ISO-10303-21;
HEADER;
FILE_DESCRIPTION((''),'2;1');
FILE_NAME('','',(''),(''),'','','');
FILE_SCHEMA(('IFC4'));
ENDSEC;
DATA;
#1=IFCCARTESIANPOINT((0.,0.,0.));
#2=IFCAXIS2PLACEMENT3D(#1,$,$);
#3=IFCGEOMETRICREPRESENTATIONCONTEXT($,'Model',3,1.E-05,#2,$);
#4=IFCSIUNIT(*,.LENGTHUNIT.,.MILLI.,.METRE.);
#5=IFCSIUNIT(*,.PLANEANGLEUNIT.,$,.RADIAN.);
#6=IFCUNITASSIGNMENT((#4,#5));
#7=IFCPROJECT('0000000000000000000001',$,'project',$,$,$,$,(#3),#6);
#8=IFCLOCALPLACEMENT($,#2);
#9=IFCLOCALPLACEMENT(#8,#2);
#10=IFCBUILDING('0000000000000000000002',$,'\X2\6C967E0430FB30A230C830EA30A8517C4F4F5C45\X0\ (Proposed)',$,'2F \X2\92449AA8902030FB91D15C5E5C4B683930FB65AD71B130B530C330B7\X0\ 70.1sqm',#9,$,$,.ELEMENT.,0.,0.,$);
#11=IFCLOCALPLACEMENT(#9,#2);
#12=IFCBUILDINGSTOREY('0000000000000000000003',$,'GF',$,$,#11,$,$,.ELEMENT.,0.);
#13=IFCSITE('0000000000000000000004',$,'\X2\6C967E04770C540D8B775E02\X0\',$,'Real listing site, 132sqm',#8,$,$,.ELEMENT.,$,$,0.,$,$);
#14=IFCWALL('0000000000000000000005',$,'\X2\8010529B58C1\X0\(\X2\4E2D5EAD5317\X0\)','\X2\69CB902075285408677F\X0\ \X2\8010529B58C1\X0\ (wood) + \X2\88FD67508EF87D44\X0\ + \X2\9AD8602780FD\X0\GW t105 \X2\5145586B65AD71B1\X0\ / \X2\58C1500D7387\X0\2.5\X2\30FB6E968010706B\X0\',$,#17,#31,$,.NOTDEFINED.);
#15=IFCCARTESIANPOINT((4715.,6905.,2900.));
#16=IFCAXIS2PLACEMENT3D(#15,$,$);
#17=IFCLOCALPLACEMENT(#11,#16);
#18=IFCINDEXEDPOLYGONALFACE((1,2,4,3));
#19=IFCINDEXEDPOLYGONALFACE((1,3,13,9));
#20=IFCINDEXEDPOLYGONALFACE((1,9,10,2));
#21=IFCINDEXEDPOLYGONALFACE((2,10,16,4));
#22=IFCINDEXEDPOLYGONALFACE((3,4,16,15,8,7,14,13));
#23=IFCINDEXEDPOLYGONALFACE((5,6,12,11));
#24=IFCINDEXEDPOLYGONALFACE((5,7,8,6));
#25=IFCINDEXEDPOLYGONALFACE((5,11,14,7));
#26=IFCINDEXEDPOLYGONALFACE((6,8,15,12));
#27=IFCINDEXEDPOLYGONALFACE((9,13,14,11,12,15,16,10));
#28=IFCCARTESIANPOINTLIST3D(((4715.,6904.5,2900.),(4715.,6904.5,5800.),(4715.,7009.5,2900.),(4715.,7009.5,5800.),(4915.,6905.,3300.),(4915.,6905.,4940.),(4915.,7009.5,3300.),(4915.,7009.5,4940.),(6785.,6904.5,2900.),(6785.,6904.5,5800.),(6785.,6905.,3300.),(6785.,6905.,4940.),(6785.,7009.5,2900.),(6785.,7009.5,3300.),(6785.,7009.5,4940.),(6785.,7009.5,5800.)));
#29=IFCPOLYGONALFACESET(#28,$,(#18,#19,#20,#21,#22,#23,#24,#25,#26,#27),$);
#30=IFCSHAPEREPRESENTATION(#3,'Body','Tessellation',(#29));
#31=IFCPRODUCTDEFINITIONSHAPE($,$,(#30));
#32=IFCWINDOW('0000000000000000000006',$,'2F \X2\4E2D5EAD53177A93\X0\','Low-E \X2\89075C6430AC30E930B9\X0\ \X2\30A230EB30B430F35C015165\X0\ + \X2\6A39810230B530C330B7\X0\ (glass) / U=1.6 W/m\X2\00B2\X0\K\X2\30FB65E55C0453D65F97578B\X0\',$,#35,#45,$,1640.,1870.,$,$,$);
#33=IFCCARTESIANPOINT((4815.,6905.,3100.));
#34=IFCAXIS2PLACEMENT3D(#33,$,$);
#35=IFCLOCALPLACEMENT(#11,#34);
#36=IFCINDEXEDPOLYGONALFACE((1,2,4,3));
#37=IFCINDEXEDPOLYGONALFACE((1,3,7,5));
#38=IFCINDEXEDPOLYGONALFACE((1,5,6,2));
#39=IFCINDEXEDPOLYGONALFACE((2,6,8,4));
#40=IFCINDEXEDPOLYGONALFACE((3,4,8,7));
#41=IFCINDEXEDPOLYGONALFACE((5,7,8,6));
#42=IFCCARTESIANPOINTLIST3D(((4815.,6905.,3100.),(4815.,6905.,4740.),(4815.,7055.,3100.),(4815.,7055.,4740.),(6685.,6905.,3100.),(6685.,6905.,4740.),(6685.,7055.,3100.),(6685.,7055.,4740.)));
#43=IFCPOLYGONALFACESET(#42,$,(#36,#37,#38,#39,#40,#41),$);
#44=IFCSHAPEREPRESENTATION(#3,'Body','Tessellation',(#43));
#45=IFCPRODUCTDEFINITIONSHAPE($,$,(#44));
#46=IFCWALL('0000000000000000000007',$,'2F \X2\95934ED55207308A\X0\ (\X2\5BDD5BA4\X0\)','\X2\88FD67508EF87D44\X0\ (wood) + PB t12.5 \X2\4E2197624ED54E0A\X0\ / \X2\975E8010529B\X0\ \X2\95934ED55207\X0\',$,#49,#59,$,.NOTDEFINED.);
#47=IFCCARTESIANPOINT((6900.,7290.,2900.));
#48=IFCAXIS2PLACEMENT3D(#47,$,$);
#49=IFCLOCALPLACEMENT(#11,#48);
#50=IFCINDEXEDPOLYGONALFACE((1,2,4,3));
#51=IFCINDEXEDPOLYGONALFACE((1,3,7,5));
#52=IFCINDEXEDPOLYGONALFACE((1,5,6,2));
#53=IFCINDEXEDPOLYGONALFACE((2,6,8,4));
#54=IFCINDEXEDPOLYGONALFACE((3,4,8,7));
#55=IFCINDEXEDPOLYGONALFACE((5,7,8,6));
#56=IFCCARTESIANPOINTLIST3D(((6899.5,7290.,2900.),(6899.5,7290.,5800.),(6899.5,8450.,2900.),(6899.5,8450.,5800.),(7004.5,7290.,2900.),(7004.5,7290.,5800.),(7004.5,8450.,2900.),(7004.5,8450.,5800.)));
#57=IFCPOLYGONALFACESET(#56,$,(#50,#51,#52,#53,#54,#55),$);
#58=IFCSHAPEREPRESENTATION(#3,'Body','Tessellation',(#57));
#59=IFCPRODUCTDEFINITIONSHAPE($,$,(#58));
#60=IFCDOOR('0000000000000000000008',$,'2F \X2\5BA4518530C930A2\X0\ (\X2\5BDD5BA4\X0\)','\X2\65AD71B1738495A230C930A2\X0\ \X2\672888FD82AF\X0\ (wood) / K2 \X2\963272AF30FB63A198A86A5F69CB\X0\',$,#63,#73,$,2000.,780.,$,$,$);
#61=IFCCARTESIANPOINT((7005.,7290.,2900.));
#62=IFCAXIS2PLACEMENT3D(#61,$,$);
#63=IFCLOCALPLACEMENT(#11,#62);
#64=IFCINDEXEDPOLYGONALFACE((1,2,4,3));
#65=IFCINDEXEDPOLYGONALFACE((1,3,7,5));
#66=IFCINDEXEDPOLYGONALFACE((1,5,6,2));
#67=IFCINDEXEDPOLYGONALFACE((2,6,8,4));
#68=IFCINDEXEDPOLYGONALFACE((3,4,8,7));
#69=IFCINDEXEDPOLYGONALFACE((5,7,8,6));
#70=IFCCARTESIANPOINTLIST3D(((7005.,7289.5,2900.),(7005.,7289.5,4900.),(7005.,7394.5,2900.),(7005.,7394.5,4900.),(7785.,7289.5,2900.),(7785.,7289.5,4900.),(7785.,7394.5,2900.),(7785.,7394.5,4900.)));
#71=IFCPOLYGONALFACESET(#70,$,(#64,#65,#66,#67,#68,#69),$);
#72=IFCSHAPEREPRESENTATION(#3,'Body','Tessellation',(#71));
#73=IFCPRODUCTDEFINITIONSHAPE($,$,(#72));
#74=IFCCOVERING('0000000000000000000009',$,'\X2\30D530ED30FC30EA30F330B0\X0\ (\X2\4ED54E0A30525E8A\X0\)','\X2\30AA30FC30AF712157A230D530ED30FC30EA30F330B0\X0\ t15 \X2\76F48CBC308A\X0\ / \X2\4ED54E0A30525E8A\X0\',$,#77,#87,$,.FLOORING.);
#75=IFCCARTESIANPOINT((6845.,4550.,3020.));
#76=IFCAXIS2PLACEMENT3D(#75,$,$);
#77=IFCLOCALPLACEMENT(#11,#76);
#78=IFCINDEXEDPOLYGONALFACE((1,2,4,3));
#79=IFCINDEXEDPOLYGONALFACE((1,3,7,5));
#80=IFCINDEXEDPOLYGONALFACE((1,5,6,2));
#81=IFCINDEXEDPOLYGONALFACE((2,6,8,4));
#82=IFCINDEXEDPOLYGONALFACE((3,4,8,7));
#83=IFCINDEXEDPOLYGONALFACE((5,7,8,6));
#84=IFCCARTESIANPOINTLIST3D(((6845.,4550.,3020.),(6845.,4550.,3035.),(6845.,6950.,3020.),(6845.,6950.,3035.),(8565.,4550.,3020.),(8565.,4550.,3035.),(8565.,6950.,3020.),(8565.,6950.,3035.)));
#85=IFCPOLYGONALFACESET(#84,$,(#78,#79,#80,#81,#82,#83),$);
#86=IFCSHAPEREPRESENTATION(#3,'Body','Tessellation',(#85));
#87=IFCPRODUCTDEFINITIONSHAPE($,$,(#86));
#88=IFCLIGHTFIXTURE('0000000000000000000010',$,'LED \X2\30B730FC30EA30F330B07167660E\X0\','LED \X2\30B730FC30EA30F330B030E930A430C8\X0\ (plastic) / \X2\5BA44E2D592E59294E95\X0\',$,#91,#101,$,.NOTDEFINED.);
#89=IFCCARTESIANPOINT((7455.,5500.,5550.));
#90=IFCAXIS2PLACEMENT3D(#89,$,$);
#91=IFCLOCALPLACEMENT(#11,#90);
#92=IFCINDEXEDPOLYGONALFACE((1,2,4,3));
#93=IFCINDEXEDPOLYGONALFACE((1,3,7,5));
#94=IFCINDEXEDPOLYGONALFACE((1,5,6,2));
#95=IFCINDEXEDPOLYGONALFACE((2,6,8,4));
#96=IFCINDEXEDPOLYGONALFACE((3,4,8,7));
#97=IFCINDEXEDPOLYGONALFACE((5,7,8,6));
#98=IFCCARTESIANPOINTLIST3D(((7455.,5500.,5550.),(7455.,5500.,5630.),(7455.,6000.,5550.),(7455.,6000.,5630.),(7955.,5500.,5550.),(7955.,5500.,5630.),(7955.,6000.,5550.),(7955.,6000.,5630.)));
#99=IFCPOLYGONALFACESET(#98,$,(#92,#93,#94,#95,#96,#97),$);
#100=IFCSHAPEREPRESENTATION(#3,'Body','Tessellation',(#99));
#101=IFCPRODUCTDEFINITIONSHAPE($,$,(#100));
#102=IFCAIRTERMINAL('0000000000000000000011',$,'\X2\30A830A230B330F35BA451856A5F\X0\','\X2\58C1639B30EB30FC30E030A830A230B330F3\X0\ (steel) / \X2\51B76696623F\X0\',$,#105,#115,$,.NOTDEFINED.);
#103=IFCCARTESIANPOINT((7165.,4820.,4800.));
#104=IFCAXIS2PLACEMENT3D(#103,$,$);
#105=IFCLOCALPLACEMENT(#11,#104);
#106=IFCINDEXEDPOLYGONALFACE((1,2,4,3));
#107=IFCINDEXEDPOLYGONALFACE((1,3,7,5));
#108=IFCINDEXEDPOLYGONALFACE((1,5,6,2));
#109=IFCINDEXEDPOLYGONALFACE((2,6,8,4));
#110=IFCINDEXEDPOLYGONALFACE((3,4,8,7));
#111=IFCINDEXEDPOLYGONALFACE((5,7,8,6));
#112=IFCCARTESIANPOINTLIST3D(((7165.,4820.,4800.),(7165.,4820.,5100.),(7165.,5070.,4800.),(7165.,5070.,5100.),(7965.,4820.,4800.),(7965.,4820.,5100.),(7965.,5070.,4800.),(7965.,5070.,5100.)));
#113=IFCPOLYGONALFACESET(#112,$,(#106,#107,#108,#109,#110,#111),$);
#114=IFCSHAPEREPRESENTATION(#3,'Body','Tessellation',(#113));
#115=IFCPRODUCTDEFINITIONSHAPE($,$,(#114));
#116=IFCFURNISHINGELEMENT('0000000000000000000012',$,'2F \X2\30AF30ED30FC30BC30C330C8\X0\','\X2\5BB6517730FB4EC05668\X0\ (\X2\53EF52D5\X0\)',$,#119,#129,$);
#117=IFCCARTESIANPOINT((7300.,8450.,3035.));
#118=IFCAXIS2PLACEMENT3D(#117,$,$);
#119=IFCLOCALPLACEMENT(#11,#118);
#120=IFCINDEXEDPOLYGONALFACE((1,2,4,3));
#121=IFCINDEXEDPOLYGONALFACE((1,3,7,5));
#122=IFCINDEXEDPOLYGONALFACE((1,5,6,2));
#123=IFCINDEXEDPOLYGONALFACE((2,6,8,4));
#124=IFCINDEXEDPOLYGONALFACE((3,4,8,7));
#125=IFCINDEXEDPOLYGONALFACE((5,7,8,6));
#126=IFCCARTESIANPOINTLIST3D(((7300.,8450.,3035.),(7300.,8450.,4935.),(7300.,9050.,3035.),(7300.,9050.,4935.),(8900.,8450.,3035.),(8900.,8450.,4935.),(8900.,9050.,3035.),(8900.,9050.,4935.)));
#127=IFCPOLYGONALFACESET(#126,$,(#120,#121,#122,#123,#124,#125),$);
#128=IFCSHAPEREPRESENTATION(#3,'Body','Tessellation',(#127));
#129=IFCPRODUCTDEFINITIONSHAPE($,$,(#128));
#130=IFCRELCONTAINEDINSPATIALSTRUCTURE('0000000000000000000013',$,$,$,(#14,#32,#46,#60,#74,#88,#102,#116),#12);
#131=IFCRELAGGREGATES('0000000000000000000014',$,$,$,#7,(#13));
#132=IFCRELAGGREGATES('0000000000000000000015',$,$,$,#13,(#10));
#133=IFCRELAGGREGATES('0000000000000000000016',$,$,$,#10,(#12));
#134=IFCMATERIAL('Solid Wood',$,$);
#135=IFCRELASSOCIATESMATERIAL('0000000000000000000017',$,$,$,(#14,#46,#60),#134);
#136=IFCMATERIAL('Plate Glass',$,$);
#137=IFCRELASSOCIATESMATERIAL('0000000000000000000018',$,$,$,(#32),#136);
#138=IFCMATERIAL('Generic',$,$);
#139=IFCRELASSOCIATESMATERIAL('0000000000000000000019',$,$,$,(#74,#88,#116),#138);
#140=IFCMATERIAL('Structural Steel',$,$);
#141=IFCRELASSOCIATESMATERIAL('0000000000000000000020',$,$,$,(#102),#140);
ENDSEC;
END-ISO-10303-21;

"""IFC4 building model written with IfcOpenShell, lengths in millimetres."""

from ifc_helpers import new_model, si_unit, frame, frame_2d, origin, place, context, project, spatial, rectangle, extrude, material, element, fill, save


model = new_model("IFC4")

# Units and contexts
model_context = context("Model", 3, precision=1e-05, world=origin())
ifc_project = project(units=[si_unit("LENGTHUNIT", "METRE", prefix="MILLI"), si_unit("PLANEANGLEUNIT", "RADIAN")], contexts=[model_context])

# Site, building, storey
site_placement = place(None, origin())
site = spatial("IfcSite", under=ifc_project, at=site_placement, Name="沖縄県名護市", ObjectType="Real listing site, 132sqm", CompositionType="ELEMENT", RefElevation=0.0)
building_placement = place(site_placement, origin())
building = spatial("IfcBuilding", under=site, at=building_placement, Name="沖縄・アトリエ兼住居 (Proposed)", ObjectType="2F 鉄骨造・金属屋根・断熱サッシ 70.1sqm", CompositionType="ELEMENT", ElevationOfRefHeight=0.0, ElevationOfTerrain=0.0)
storey_placement = place(building_placement, origin())
storey = spatial("IfcBuildingStorey", under=building, at=storey_placement, Name="GF", CompositionType="ELEMENT", Elevation=0.0)

# Shared definitions
ifc_material_1 = material(Name="Solid Wood")

# Wall, opening, window
wall_1_placement = place(storey_placement, frame((4715.0, 6905.0, 2900.0)))
wall_1 = element("IfcWall", 1, at=wall_1_placement, inside=storey, material=ifc_material_1, Name="耐力壁(中庭北)", Description="構造用合板 耐力壁 (wood) + 製材軸組 + 高性能GW t105 充填断熱 / 壁倍率2.5・準耐火", PredefinedType="NOTDEFINED", context=model_context, shape_type="SweptSolid", body=[
    extrude(rectangle(XDim=2070.0, YDim=105.0, at=frame_2d((1035.0, 52.0))), frame((4715.0, 6905.0, 2900.0)), (0.0, 0.0, 1.0), 2900.0),
])
opening_placement = place(storey_placement, frame((4815.0, 6905.0, 3100.0)))
opening = element("IfcOpeningElement", 2, at=opening_placement, cuts=wall_1, PredefinedType="NOTDEFINED", context=model_context, shape_type="SweptSolid", body=[
    extrude(rectangle(XDim=1870.0, YDim=150.0, at=frame_2d((935.0, 75.0))), frame((4815.0, 6905.0, 3100.0)), (0.0, 0.0, 1.0), 1640.0),
])
ifc_material_2 = material(Name="Plate Glass")
window_placement = place(storey_placement, frame((4815.0, 6905.0, 3100.0)))
window = element("IfcWindow", 3, at=window_placement, inside=storey, material=ifc_material_2, Name="2F 中庭北窓", Description="Low-E 複層ガラス アルゴン封入 + 樹脂サッシ (glass) / U=1.6 W/m²K・日射取得型", OverallHeight=1640.0, OverallWidth=1870.0, context=model_context, shape_type="SweptSolid", body=[
    extrude(rectangle(XDim=1870.0, YDim=150.0, at=frame_2d((935.0, 75.0))), frame((4815.0, 6905.0, 3100.0)), (0.0, 0.0, 1.0), 1640.0),
])
fill(opening, window)

# Wall
wall_2_placement = place(storey_placement, frame((6900.0, 7290.0, 2900.0)))
element("IfcWall", 4, at=wall_2_placement, inside=storey, material=ifc_material_1, Name="2F 間仕切り (寝室)", Description="製材軸組 (wood) + PB t12.5 両面仕上 / 非耐力 間仕切", PredefinedType="NOTDEFINED", context=model_context, shape_type="SweptSolid", body=[
    extrude(rectangle(XDim=105.0, YDim=1160.0, at=frame_2d((52.0, 580.0))), frame((6900.0, 7290.0, 2900.0)), (0.0, 0.0, 1.0), 2900.0),
])

# Door
door_placement = place(storey_placement, frame((7005.0, 7290.0, 2900.0)))
element("IfcDoor", 5, at=door_placement, inside=storey, material=ifc_material_1, Name="2F 室内ドア (寝室)", Description="断熱玄関ドア 木製芯 (wood) / K2 防犯・採風機構", OverallHeight=2000.0, OverallWidth=780.0, context=model_context, shape_type="SweptSolid", body=[
    extrude(rectangle(XDim=780.0, YDim=105.0, at=frame_2d((390.0, 52.0))), frame((7005.0, 7290.0, 2900.0)), (0.0, 0.0, 1.0), 2000.0),
])

# Covering
ifc_material_3 = material(Name="Generic")
covering_placement = place(storey_placement, frame((6845.0, 4550.0, 3020.0)))
element("IfcCovering", 6, at=covering_placement, inside=storey, material=ifc_material_3, Name="フローリング (仕上げ床)", Description="オーク無垢フローリング t15 直貼り / 仕上げ床", PredefinedType="FLOORING", context=model_context, shape_type="SweptSolid", body=[
    extrude(rectangle(XDim=1720.0, YDim=2400.0, at=frame_2d((860.0, 1200.0))), frame((6845.0, 4550.0, 3020.0)), (0.0, 0.0, 1.0), 15.0),
])

# Light fixture
light_fixture_placement = place(storey_placement, frame((7455.0, 5500.0, 5550.0)))
element("IfcLightFixture", 7, at=light_fixture_placement, inside=storey, material=ifc_material_3, Name="LED シーリング照明", Description="LED シーリングライト (plastic) / 室中央天井", PredefinedType="NOTDEFINED", context=model_context, shape_type="SweptSolid", body=[
    extrude(rectangle(XDim=500.0, YDim=500.0, at=frame_2d((250.0, 250.0))), frame((7455.0, 5500.0, 5550.0)), (0.0, 0.0, 1.0), 80.0),
])

# Air terminal
ifc_material_4 = material(Name="Structural Steel")
air_terminal_placement = place(storey_placement, frame((7165.0, 4820.0, 4800.0)))
element("IfcAirTerminal", 8, at=air_terminal_placement, inside=storey, material=ifc_material_4, Name="エアコン室内機", Description="壁掛ルームエアコン (steel) / 冷暖房", PredefinedType="NOTDEFINED", context=model_context, shape_type="SweptSolid", body=[
    extrude(rectangle(XDim=800.0, YDim=250.0, at=frame_2d((400.0, 125.0))), frame((7165.0, 4820.0, 4800.0)), (0.0, 0.0, 1.0), 300.0),
])

# Furnishing element
furnishing_placement = place(storey_placement, frame((7300.0, 8450.0, 3035.0)))
element("IfcFurnishingElement", 9, at=furnishing_placement, inside=storey, material=ifc_material_3, Name="2F クローゼット", Description="家具・什器 (可動)", context=model_context, shape_type="SweptSolid", body=[
    extrude(rectangle(XDim=1600.0, YDim=600.0, at=frame_2d((800.0, 300.0))), frame((7300.0, 8450.0, 3035.0)), (0.0, 0.0, 1.0), 1900.0),
])

save(model, "model.ifc")
